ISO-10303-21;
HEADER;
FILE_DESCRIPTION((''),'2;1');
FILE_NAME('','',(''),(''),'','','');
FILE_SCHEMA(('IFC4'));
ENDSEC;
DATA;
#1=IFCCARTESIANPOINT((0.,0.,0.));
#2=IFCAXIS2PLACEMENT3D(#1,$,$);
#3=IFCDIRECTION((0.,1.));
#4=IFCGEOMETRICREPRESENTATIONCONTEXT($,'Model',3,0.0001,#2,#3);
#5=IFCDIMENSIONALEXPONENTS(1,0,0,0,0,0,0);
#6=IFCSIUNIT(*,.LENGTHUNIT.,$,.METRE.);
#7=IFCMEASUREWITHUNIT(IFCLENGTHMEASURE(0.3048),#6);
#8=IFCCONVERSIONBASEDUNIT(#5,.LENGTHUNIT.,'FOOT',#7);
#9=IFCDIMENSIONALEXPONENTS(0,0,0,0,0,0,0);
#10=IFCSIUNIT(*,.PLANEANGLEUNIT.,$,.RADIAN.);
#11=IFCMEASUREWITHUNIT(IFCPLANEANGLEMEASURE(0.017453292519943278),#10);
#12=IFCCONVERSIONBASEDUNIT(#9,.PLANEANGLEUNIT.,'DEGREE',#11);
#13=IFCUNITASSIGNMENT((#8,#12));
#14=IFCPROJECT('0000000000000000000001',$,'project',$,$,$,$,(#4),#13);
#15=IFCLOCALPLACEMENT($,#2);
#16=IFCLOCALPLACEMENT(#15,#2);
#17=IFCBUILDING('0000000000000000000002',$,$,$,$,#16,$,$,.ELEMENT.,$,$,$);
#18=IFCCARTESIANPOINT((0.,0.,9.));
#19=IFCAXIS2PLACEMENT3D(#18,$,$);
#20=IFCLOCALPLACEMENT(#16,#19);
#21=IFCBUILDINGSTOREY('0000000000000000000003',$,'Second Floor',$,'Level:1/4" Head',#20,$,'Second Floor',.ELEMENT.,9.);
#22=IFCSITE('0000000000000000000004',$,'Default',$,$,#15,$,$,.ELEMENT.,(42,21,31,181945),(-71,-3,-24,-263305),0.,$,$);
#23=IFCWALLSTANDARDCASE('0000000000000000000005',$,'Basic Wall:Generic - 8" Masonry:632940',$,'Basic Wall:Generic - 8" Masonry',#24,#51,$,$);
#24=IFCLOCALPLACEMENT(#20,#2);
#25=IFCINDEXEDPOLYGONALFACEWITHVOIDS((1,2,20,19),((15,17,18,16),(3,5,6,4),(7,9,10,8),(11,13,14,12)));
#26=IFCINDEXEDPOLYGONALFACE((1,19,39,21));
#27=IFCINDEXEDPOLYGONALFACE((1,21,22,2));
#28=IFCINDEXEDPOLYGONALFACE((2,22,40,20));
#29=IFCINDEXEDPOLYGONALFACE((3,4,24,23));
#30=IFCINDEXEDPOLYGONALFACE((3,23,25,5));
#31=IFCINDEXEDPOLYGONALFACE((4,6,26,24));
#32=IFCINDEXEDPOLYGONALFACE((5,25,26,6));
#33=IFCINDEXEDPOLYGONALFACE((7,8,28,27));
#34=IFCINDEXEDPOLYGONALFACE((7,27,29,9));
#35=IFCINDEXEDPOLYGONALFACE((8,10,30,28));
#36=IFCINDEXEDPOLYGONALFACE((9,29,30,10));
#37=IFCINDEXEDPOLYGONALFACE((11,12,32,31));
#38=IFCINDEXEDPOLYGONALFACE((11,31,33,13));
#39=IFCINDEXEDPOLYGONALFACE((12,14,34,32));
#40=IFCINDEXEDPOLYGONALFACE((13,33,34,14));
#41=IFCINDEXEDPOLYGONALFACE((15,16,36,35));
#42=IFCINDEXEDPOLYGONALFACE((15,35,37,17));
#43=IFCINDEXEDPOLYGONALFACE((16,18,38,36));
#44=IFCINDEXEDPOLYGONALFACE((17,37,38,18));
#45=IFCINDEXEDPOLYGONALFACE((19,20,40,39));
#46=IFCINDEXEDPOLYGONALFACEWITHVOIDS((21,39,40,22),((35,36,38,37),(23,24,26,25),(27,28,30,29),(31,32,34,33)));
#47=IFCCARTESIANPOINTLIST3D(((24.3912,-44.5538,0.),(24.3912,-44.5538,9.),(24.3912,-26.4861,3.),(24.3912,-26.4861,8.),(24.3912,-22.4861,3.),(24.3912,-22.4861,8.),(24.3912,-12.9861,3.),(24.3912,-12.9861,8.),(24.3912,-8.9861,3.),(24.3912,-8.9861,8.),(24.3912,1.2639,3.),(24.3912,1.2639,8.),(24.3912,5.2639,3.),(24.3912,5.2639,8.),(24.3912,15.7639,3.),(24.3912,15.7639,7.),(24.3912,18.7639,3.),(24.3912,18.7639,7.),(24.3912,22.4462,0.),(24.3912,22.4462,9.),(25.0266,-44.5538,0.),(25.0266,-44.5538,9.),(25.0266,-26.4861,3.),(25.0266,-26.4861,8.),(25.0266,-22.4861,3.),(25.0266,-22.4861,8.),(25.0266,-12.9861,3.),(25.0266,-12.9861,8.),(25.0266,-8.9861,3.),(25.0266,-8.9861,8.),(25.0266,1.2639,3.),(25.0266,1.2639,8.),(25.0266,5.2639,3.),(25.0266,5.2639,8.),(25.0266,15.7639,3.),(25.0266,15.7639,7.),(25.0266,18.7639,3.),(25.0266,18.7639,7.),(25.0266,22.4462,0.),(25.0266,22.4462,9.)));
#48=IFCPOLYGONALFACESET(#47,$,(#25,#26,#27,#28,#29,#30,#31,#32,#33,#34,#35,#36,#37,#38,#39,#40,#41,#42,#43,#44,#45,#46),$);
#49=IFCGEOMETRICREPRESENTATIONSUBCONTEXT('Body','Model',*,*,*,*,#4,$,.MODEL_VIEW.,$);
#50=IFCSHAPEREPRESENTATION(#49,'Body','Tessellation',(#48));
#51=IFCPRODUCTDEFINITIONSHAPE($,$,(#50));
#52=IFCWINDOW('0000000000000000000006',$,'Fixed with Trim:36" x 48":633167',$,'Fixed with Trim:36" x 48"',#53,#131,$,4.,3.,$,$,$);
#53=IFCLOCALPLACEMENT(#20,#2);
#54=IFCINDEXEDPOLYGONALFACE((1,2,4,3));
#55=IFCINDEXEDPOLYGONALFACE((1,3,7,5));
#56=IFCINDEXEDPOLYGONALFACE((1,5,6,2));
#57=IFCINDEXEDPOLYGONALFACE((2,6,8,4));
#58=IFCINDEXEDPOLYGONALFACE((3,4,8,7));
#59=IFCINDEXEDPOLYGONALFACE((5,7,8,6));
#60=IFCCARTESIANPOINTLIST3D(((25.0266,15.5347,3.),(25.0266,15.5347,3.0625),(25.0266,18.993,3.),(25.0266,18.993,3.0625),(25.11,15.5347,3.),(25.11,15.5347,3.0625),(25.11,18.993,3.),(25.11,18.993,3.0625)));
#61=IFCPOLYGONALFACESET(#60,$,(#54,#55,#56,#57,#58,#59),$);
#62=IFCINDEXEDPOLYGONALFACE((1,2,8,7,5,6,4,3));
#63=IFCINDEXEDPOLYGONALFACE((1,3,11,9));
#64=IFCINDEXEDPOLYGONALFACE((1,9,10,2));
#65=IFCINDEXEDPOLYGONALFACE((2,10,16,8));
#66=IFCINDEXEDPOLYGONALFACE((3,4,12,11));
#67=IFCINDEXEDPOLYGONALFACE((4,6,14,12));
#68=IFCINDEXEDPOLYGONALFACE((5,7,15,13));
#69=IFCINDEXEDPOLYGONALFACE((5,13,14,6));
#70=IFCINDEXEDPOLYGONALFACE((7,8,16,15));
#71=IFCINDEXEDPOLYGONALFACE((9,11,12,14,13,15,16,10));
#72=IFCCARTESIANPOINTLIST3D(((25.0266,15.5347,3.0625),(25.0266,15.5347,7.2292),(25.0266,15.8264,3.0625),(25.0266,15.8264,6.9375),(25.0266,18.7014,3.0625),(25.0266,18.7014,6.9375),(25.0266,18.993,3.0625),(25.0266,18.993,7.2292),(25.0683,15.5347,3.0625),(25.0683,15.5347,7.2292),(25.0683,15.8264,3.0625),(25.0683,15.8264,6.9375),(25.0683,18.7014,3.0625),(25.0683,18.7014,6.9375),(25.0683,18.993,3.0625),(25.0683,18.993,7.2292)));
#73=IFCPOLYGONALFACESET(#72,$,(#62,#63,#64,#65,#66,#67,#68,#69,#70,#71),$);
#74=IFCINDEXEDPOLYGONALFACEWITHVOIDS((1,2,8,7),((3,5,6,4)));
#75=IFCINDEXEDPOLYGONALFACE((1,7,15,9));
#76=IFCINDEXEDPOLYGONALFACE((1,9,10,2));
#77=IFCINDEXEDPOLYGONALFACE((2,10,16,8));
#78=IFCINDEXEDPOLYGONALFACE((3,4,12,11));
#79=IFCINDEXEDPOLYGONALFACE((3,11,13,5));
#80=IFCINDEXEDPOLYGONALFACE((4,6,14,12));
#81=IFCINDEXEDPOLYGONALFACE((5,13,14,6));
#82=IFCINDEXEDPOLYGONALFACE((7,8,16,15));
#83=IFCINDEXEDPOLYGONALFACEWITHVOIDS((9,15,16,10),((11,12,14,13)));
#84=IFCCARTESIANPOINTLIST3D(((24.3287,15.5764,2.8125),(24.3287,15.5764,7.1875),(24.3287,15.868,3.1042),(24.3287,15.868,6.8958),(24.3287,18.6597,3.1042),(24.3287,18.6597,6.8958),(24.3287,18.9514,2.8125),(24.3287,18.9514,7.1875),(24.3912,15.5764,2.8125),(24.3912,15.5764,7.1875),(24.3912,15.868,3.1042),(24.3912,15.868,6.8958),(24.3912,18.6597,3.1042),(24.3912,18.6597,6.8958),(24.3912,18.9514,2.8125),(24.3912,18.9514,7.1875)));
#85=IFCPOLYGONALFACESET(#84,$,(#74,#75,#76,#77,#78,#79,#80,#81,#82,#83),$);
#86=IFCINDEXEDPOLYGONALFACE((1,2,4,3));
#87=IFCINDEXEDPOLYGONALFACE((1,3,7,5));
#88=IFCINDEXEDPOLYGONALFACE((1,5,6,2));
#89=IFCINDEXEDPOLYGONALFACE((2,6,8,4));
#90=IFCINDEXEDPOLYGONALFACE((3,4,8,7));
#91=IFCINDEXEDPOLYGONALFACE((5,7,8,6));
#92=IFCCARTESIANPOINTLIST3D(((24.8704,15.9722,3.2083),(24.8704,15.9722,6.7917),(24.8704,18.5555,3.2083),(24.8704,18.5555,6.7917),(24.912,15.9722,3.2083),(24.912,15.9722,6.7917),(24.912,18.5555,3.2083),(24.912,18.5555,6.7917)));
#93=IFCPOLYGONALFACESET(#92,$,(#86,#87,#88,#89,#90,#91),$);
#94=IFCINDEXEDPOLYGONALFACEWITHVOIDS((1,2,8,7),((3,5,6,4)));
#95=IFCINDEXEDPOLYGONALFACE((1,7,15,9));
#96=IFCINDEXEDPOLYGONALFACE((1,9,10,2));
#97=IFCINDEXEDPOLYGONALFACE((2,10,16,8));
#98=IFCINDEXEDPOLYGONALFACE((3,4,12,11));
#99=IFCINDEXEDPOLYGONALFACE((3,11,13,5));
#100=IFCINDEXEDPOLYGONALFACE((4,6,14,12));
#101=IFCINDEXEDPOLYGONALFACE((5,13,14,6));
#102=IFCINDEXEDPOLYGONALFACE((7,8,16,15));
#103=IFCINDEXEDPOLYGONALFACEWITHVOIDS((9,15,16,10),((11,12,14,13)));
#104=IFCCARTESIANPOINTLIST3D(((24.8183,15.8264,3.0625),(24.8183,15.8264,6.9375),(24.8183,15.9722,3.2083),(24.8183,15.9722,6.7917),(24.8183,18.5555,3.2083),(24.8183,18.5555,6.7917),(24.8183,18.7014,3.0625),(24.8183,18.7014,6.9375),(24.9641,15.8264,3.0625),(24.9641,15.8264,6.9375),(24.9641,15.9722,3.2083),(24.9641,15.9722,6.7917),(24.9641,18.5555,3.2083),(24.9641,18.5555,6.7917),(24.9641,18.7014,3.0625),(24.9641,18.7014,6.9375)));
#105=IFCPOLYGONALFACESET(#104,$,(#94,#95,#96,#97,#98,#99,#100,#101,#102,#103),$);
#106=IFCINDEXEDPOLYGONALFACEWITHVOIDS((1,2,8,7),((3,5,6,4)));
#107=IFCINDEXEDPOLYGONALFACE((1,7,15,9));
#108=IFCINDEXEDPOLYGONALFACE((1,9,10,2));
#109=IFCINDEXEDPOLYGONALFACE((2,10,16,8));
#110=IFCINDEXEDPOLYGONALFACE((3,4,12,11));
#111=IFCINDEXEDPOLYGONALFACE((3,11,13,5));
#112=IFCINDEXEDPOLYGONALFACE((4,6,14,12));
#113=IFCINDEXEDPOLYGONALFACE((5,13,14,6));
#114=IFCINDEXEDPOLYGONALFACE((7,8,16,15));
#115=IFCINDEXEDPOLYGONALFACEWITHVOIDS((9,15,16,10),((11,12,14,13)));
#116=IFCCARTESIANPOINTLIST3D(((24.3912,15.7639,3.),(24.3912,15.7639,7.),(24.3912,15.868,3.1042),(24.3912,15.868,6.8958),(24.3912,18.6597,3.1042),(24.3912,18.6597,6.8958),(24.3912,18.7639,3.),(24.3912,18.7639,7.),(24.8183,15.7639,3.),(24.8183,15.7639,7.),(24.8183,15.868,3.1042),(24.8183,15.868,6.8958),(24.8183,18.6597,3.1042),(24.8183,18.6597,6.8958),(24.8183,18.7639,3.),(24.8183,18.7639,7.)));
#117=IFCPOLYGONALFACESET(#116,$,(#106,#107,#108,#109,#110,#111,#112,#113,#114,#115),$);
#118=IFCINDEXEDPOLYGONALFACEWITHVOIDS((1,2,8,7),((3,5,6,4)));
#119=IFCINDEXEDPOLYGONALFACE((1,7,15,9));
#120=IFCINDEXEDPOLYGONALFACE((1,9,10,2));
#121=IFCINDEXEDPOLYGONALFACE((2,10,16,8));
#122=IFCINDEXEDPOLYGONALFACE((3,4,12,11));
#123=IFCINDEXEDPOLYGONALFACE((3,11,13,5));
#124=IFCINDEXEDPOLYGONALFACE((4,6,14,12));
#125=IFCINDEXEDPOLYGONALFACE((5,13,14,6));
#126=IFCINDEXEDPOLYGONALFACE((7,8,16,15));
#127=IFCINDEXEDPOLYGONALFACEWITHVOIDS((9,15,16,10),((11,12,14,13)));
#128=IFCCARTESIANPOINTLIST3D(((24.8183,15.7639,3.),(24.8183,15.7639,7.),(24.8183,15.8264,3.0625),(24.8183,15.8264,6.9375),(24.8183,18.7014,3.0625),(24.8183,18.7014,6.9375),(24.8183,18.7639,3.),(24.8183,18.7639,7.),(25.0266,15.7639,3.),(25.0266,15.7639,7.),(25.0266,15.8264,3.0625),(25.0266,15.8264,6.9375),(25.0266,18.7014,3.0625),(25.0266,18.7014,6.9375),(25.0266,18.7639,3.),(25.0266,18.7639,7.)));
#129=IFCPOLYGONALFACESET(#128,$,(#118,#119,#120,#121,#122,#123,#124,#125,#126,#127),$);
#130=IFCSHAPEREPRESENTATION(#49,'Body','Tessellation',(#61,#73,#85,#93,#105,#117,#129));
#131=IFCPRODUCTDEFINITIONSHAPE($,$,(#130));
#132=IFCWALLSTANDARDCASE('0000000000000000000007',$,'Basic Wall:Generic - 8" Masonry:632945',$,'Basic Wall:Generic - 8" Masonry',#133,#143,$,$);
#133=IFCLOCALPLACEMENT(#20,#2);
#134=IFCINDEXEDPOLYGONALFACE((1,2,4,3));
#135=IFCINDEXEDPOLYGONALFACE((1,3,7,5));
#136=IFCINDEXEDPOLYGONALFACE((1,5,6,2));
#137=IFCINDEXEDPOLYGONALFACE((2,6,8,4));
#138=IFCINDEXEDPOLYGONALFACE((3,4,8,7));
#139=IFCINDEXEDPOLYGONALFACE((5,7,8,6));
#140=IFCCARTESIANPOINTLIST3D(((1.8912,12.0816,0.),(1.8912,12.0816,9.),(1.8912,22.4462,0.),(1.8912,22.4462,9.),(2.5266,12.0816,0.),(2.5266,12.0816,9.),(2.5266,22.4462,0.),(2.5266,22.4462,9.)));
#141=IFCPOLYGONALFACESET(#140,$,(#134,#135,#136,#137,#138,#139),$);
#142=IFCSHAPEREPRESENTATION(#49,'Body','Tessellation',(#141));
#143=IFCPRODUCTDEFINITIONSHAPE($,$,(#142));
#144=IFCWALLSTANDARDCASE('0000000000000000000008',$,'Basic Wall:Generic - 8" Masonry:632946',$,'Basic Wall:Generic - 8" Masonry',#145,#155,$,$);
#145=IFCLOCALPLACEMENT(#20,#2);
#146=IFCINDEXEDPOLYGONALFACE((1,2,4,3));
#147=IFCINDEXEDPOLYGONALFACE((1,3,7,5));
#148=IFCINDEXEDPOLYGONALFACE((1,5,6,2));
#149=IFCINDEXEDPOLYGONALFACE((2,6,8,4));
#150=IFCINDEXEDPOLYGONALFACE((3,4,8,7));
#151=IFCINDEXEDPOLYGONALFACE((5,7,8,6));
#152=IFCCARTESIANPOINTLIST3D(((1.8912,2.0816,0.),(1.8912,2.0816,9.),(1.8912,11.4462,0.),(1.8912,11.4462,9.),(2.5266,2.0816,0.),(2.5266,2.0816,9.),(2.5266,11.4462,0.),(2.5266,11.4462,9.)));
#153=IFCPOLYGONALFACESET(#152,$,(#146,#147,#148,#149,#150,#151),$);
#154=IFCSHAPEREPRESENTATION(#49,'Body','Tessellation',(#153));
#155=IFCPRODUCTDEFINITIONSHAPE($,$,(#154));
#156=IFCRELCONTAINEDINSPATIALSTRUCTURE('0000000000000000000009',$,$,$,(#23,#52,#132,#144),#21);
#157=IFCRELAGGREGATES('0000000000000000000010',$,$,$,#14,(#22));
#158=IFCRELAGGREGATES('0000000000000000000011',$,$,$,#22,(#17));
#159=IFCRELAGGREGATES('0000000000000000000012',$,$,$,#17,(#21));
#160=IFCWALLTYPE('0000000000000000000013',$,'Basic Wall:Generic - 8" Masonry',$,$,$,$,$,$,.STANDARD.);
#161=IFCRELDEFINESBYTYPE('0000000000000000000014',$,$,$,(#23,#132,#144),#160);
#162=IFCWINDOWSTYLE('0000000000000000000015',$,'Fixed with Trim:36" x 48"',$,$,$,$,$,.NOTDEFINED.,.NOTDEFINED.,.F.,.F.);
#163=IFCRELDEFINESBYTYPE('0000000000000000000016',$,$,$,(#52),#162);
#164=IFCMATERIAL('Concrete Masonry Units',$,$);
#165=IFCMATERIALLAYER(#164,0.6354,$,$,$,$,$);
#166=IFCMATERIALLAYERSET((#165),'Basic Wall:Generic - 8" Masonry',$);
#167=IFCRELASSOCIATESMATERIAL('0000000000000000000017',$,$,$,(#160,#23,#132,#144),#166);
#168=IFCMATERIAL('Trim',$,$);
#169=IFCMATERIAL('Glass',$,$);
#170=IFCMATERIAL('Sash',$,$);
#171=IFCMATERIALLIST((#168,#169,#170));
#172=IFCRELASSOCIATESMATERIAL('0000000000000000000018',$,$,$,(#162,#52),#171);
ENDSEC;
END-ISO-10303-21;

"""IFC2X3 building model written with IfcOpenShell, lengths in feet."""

from ifc_helpers import new_model, entity, si_unit, converted_unit, direction, frame, frame_2d, origin, origin_2d_with_axis, place, context, subcontext, project, spatial, polyline, rectangle, outline, extrude, source, transform, mapped, material, material_list, layer, layer_set, layer_usage, type_object, type_shapes, element, fill, save


model = new_model("IFC2X3")

# Units and contexts
model_context = context("Model", 3, precision=0.0001, world=origin(), true_north=direction((0.0, 1.0)))
body_context = subcontext(model_context, "Body", "Model", "MODEL_VIEW")
ifc_project = project(units=[converted_unit("LENGTHUNIT", "FOOT", entity("IfcLengthMeasure", 0.3048), si_unit("LENGTHUNIT", "METRE"), dimensions=[1, 0, 0, 0, 0, 0, 0]), converted_unit("PLANEANGLEUNIT", "DEGREE", entity("IfcPlaneAngleMeasure", 0.017453292519943278), si_unit("PLANEANGLEUNIT", "RADIAN"), dimensions=[0, 0, 0, 0, 0, 0, 0])], contexts=[model_context])

# Site, building, storey
site_placement = place(None, origin())
site = spatial("IfcSite", under=ifc_project, at=site_placement, Name="Default", CompositionType="ELEMENT", RefLatitude=(42, 21, 31, 181945), RefLongitude=(-71, -3, -24, -263305), RefElevation=0.0)
building_placement = place(site_placement, origin())
building = spatial("IfcBuilding", under=site, at=building_placement, CompositionType="ELEMENT")
storey_placement = place(building_placement, frame((0.0, 0.0, 9.0)))
storey = spatial("IfcBuildingStorey", under=building, at=storey_placement, Name="Second Floor", ObjectType="Level:1/4\" Head", LongName="Second Floor", CompositionType="ELEMENT", Elevation=9.0)

# Wall, openings, window
ifc_material_1 = material(Name="Concrete Masonry Units")
ifc_layer_1 = layer(ifc_material_1, 0.6354)
ifc_layer_set_1 = layer_set([ifc_layer_1], Name="Basic Wall:Generic - 8\" Masonry")
ifc_layer_usage_1 = layer_usage(ifc_layer_set_1, "AXIS2", "NEGATIVE", 0.3177)
wall_type = type_object("IfcWallType", Name="Basic Wall:Generic - 8\" Masonry", PredefinedType="STANDARD", material=ifc_layer_set_1)
wall_1_placement = place(storey_placement, frame((24.7089, 22.4462, 0.0), z_axis=(0.0, 0.0, 1.0), x_axis=(0.0, -1.0, 0.0)))
wall_1 = element("IfcWallStandardCase", 1, at=wall_1_placement, inside=storey, type_object=wall_type, material=ifc_layer_usage_1, Name="Basic Wall:Generic - 8\" Masonry:632940", ObjectType="Basic Wall:Generic - 8\" Masonry", context=body_context, shape_type="SweptSolid", body=[
    extrude(rectangle(XDim=67.0, YDim=0.6354, at=frame_2d((33.5, 0.0), x_axis=(-1.0, 0.0))), origin(), (0.0, 0.0, 1.0), 9.0),
])
opening_1_placement = place(wall_1_placement, frame((3.6823, -0.3177, 3.0)))
opening_1 = element("IfcOpeningElement", 2, at=opening_1_placement, cuts=wall_1, ObjectType="Opening", context=body_context, shape_type="SweptSolid", body=[
    extrude(rectangle(XDim=4.0, YDim=3.0, at=frame_2d((2.0, 1.5), x_axis=(-1.0, 0.0))), frame((0.0, 0.0, 0.0), z_axis=(0.0, 1.0, 0.0), x_axis=(0.0, 0.0, 1.0)), (0.0, 0.0, 1.0), 0.6354),
])
opening_2_placement = place(wall_1_placement, frame((31.4323, -0.3177, 3.0)))
element("IfcOpeningElement", 3, at=opening_2_placement, cuts=wall_1, ObjectType="Opening", context=body_context, shape_type="SweptSolid", body=[
    extrude(rectangle(XDim=5.0, YDim=4.0, at=frame_2d((2.5, 2.0), x_axis=(-1.0, 0.0))), frame((0.0, 0.0, 0.0), z_axis=(0.0, 1.0, 0.0), x_axis=(0.0, 0.0, 1.0)), (0.0, 0.0, 1.0), 0.6354),
])
opening_3_placement = place(wall_1_placement, frame((44.9323, -0.3177, 3.0)))
element("IfcOpeningElement", 4, at=opening_3_placement, cuts=wall_1, ObjectType="Opening", context=body_context, shape_type="SweptSolid", body=[
    extrude(rectangle(XDim=5.0, YDim=4.0, at=frame_2d((2.5, 2.0), x_axis=(-1.0, 0.0))), frame((0.0, 0.0, 0.0), z_axis=(0.0, 1.0, 0.0), x_axis=(0.0, 0.0, 1.0)), (0.0, 0.0, 1.0), 0.6354),
])
opening_4_placement = place(wall_1_placement, frame((17.1823, -0.3177, 3.0)))
element("IfcOpeningElement", 5, at=opening_4_placement, cuts=wall_1, ObjectType="Opening", context=body_context, shape_type="SweptSolid", body=[
    extrude(rectangle(XDim=5.0, YDim=4.0, at=frame_2d((2.5, 2.0), x_axis=(-1.0, 0.0))), frame((0.0, 0.0, 0.0), z_axis=(0.0, 1.0, 0.0), x_axis=(0.0, 0.0, 1.0)), (0.0, 0.0, 1.0), 0.6354),
])
ifc_material_2 = material(Name="Trim")
ifc_material_3 = material(Name="Glass")
ifc_material_4 = material(Name="Sash")
ifc_material_list_1 = material_list([ifc_material_2, ifc_material_3, ifc_material_4])
window_style = type_object("IfcWindowStyle", Name="Fixed with Trim:36\" x 48\"", ConstructionType="NOTDEFINED", OperationType="NOTDEFINED", ParameterTakesPrecedence=False, Sizeable=False, material=ifc_material_list_1)
shared_shape_1 = source(origin(), body_context, "Body", "SweptSolid", [
    extrude(rectangle(XDim=0.0833, YDim=3.4583, at=origin_2d_with_axis()), frame((1.5, 0.6771, 0.0), z_axis=(0.0, 0.0, 1.0), x_axis=(0.0, -1.0, 0.0)), (0.0, 0.0, 1.0), 0.0625),
    extrude(outline(polyline([(-1.8646, 1.4375), (2.0104, 1.4375), (2.0104, 1.7292), (-2.1562, 1.7292), (-2.1562, -1.7292), (2.0104, -1.7292), (2.0104, -1.4375), (-1.8646, -1.4375), (-1.8646, 1.4375)])), frame((1.5, 0.6354, 2.0729), z_axis=(0.0, 1.0, 0.0), x_axis=(0.0, 0.0, -1.0)), (0.0, 0.0, 1.0), 0.0417),
    extrude(outline(polyline([(-2.1875, -1.6875), (2.1875, -1.6875), (2.1875, 1.6875), (-2.1875, 1.6875), (-2.1875, -1.6875)]), holes=[polyline([(-1.8958, -1.3958), (-1.8958, 1.3958), (1.8958, 1.3958), (1.8958, -1.3958), (-1.8958, -1.3958)])]), frame((1.5, -0.0625, 2.0), z_axis=(0.0, 1.0, 0.0), x_axis=(0.0, 0.0, -1.0)), (0.0, 0.0, 1.0), 0.0625),
    extrude(rectangle(XDim=0.0417, YDim=2.5833, at=frame_2d((0.0, 0.0), x_axis=(1.0, 0.0))), frame((1.5, 0.5, 0.2083), z_axis=(0.0, 0.0, 1.0), x_axis=(0.0, 1.0, 0.0)), (0.0, 0.0, 1.0), 3.5833),
    extrude(outline(polyline([(-1.4375, -1.9375), (1.4375, -1.9375), (1.4375, 1.9375), (-1.4375, 1.9375), (-1.4375, -1.9375)]), holes=[polyline([(-1.2917, -1.7917), (-1.2917, 1.7917), (1.2917, 1.7917), (1.2917, -1.7917), (-1.2917, -1.7917)])]), frame((1.5, 0.4271, 2.0), z_axis=(0.0, 1.0, 0.0), x_axis=(1.0, 0.0, 0.0)), (0.0, 0.0, 1.0), 0.1458),
    extrude(outline(polyline([(-1.5, -2.0), (1.5, -2.0), (1.5, 2.0), (-1.5, 2.0), (-1.5, -2.0)]), holes=[polyline([(-1.3958, -1.8958), (-1.3958, 1.8958), (1.3958, 1.8958), (1.3958, -1.8958), (-1.3958, -1.8958)])]), frame((1.5, 0.0, 2.0), z_axis=(0.0, 1.0, 0.0), x_axis=(1.0, 0.0, 0.0)), (0.0, 0.0, 1.0), 0.4271),
    extrude(outline(polyline([(-2.0, -1.5), (2.0, -1.5), (2.0, 1.5), (-2.0, 1.5), (-2.0, -1.5)]), holes=[polyline([(-1.9375, -1.4375), (-1.9375, 1.4375), (1.9375, 1.4375), (1.9375, -1.4375), (-1.9375, -1.4375)])]), frame((1.5, 0.4271, 2.0), z_axis=(0.0, 1.0, 0.0), x_axis=(0.0, 0.0, -1.0)), (0.0, 0.0, 1.0), 0.2083),
])
type_shapes(window_style, [shared_shape_1])
window_placement = place(opening_1_placement, origin())
window = element("IfcWindow", 6, at=window_placement, inside=storey, type_object=window_style, material=ifc_material_list_1, Name="Fixed with Trim:36\" x 48\":633167", ObjectType="Fixed with Trim:36\" x 48\"", OverallHeight=4.0, OverallWidth=3.0, context=body_context, shape_type="MappedRepresentation", body=[
    mapped(shared_shape_1, transform((0.0, 0.0, 0.0), scale=1.0)),
])
fill(opening_1, window)

# Walls
ifc_layer_usage_2 = layer_usage(ifc_layer_set_1, "AXIS2", "NEGATIVE", 0.3177)
wall_2_placement = place(storey_placement, frame((2.2089, 22.4462, 0.0), z_axis=(0.0, 0.0, 1.0), x_axis=(0.0, -1.0, 0.0)))
element("IfcWallStandardCase", 7, at=wall_2_placement, inside=storey, type_object=wall_type, material=ifc_layer_usage_2, Name="Basic Wall:Generic - 8\" Masonry:632945", ObjectType="Basic Wall:Generic - 8\" Masonry", context=body_context, shape_type="SweptSolid", body=[
    extrude(rectangle(XDim=10.3646, YDim=0.6354, at=frame_2d((5.1823, 0.0), x_axis=(-1.0, 0.0))), origin(), (0.0, 0.0, 1.0), 9.0),
])
ifc_layer_usage_3 = layer_usage(ifc_layer_set_1, "AXIS2", "NEGATIVE", 0.3177)
wall_3_placement = place(storey_placement, frame((2.2089, 11.4462, 0.0), z_axis=(0.0, 0.0, 1.0), x_axis=(0.0, -1.0, 0.0)))
element("IfcWallStandardCase", 8, at=wall_3_placement, inside=storey, type_object=wall_type, material=ifc_layer_usage_3, Name="Basic Wall:Generic - 8\" Masonry:632946", ObjectType="Basic Wall:Generic - 8\" Masonry", context=body_context, shape_type="SweptSolid", body=[
    extrude(rectangle(XDim=9.3646, YDim=0.6354, at=frame_2d((4.6823, 0.0), x_axis=(-1.0, 0.0))), origin(), (0.0, 0.0, 1.0), 9.0),
])

save(model, "model.ifc")
